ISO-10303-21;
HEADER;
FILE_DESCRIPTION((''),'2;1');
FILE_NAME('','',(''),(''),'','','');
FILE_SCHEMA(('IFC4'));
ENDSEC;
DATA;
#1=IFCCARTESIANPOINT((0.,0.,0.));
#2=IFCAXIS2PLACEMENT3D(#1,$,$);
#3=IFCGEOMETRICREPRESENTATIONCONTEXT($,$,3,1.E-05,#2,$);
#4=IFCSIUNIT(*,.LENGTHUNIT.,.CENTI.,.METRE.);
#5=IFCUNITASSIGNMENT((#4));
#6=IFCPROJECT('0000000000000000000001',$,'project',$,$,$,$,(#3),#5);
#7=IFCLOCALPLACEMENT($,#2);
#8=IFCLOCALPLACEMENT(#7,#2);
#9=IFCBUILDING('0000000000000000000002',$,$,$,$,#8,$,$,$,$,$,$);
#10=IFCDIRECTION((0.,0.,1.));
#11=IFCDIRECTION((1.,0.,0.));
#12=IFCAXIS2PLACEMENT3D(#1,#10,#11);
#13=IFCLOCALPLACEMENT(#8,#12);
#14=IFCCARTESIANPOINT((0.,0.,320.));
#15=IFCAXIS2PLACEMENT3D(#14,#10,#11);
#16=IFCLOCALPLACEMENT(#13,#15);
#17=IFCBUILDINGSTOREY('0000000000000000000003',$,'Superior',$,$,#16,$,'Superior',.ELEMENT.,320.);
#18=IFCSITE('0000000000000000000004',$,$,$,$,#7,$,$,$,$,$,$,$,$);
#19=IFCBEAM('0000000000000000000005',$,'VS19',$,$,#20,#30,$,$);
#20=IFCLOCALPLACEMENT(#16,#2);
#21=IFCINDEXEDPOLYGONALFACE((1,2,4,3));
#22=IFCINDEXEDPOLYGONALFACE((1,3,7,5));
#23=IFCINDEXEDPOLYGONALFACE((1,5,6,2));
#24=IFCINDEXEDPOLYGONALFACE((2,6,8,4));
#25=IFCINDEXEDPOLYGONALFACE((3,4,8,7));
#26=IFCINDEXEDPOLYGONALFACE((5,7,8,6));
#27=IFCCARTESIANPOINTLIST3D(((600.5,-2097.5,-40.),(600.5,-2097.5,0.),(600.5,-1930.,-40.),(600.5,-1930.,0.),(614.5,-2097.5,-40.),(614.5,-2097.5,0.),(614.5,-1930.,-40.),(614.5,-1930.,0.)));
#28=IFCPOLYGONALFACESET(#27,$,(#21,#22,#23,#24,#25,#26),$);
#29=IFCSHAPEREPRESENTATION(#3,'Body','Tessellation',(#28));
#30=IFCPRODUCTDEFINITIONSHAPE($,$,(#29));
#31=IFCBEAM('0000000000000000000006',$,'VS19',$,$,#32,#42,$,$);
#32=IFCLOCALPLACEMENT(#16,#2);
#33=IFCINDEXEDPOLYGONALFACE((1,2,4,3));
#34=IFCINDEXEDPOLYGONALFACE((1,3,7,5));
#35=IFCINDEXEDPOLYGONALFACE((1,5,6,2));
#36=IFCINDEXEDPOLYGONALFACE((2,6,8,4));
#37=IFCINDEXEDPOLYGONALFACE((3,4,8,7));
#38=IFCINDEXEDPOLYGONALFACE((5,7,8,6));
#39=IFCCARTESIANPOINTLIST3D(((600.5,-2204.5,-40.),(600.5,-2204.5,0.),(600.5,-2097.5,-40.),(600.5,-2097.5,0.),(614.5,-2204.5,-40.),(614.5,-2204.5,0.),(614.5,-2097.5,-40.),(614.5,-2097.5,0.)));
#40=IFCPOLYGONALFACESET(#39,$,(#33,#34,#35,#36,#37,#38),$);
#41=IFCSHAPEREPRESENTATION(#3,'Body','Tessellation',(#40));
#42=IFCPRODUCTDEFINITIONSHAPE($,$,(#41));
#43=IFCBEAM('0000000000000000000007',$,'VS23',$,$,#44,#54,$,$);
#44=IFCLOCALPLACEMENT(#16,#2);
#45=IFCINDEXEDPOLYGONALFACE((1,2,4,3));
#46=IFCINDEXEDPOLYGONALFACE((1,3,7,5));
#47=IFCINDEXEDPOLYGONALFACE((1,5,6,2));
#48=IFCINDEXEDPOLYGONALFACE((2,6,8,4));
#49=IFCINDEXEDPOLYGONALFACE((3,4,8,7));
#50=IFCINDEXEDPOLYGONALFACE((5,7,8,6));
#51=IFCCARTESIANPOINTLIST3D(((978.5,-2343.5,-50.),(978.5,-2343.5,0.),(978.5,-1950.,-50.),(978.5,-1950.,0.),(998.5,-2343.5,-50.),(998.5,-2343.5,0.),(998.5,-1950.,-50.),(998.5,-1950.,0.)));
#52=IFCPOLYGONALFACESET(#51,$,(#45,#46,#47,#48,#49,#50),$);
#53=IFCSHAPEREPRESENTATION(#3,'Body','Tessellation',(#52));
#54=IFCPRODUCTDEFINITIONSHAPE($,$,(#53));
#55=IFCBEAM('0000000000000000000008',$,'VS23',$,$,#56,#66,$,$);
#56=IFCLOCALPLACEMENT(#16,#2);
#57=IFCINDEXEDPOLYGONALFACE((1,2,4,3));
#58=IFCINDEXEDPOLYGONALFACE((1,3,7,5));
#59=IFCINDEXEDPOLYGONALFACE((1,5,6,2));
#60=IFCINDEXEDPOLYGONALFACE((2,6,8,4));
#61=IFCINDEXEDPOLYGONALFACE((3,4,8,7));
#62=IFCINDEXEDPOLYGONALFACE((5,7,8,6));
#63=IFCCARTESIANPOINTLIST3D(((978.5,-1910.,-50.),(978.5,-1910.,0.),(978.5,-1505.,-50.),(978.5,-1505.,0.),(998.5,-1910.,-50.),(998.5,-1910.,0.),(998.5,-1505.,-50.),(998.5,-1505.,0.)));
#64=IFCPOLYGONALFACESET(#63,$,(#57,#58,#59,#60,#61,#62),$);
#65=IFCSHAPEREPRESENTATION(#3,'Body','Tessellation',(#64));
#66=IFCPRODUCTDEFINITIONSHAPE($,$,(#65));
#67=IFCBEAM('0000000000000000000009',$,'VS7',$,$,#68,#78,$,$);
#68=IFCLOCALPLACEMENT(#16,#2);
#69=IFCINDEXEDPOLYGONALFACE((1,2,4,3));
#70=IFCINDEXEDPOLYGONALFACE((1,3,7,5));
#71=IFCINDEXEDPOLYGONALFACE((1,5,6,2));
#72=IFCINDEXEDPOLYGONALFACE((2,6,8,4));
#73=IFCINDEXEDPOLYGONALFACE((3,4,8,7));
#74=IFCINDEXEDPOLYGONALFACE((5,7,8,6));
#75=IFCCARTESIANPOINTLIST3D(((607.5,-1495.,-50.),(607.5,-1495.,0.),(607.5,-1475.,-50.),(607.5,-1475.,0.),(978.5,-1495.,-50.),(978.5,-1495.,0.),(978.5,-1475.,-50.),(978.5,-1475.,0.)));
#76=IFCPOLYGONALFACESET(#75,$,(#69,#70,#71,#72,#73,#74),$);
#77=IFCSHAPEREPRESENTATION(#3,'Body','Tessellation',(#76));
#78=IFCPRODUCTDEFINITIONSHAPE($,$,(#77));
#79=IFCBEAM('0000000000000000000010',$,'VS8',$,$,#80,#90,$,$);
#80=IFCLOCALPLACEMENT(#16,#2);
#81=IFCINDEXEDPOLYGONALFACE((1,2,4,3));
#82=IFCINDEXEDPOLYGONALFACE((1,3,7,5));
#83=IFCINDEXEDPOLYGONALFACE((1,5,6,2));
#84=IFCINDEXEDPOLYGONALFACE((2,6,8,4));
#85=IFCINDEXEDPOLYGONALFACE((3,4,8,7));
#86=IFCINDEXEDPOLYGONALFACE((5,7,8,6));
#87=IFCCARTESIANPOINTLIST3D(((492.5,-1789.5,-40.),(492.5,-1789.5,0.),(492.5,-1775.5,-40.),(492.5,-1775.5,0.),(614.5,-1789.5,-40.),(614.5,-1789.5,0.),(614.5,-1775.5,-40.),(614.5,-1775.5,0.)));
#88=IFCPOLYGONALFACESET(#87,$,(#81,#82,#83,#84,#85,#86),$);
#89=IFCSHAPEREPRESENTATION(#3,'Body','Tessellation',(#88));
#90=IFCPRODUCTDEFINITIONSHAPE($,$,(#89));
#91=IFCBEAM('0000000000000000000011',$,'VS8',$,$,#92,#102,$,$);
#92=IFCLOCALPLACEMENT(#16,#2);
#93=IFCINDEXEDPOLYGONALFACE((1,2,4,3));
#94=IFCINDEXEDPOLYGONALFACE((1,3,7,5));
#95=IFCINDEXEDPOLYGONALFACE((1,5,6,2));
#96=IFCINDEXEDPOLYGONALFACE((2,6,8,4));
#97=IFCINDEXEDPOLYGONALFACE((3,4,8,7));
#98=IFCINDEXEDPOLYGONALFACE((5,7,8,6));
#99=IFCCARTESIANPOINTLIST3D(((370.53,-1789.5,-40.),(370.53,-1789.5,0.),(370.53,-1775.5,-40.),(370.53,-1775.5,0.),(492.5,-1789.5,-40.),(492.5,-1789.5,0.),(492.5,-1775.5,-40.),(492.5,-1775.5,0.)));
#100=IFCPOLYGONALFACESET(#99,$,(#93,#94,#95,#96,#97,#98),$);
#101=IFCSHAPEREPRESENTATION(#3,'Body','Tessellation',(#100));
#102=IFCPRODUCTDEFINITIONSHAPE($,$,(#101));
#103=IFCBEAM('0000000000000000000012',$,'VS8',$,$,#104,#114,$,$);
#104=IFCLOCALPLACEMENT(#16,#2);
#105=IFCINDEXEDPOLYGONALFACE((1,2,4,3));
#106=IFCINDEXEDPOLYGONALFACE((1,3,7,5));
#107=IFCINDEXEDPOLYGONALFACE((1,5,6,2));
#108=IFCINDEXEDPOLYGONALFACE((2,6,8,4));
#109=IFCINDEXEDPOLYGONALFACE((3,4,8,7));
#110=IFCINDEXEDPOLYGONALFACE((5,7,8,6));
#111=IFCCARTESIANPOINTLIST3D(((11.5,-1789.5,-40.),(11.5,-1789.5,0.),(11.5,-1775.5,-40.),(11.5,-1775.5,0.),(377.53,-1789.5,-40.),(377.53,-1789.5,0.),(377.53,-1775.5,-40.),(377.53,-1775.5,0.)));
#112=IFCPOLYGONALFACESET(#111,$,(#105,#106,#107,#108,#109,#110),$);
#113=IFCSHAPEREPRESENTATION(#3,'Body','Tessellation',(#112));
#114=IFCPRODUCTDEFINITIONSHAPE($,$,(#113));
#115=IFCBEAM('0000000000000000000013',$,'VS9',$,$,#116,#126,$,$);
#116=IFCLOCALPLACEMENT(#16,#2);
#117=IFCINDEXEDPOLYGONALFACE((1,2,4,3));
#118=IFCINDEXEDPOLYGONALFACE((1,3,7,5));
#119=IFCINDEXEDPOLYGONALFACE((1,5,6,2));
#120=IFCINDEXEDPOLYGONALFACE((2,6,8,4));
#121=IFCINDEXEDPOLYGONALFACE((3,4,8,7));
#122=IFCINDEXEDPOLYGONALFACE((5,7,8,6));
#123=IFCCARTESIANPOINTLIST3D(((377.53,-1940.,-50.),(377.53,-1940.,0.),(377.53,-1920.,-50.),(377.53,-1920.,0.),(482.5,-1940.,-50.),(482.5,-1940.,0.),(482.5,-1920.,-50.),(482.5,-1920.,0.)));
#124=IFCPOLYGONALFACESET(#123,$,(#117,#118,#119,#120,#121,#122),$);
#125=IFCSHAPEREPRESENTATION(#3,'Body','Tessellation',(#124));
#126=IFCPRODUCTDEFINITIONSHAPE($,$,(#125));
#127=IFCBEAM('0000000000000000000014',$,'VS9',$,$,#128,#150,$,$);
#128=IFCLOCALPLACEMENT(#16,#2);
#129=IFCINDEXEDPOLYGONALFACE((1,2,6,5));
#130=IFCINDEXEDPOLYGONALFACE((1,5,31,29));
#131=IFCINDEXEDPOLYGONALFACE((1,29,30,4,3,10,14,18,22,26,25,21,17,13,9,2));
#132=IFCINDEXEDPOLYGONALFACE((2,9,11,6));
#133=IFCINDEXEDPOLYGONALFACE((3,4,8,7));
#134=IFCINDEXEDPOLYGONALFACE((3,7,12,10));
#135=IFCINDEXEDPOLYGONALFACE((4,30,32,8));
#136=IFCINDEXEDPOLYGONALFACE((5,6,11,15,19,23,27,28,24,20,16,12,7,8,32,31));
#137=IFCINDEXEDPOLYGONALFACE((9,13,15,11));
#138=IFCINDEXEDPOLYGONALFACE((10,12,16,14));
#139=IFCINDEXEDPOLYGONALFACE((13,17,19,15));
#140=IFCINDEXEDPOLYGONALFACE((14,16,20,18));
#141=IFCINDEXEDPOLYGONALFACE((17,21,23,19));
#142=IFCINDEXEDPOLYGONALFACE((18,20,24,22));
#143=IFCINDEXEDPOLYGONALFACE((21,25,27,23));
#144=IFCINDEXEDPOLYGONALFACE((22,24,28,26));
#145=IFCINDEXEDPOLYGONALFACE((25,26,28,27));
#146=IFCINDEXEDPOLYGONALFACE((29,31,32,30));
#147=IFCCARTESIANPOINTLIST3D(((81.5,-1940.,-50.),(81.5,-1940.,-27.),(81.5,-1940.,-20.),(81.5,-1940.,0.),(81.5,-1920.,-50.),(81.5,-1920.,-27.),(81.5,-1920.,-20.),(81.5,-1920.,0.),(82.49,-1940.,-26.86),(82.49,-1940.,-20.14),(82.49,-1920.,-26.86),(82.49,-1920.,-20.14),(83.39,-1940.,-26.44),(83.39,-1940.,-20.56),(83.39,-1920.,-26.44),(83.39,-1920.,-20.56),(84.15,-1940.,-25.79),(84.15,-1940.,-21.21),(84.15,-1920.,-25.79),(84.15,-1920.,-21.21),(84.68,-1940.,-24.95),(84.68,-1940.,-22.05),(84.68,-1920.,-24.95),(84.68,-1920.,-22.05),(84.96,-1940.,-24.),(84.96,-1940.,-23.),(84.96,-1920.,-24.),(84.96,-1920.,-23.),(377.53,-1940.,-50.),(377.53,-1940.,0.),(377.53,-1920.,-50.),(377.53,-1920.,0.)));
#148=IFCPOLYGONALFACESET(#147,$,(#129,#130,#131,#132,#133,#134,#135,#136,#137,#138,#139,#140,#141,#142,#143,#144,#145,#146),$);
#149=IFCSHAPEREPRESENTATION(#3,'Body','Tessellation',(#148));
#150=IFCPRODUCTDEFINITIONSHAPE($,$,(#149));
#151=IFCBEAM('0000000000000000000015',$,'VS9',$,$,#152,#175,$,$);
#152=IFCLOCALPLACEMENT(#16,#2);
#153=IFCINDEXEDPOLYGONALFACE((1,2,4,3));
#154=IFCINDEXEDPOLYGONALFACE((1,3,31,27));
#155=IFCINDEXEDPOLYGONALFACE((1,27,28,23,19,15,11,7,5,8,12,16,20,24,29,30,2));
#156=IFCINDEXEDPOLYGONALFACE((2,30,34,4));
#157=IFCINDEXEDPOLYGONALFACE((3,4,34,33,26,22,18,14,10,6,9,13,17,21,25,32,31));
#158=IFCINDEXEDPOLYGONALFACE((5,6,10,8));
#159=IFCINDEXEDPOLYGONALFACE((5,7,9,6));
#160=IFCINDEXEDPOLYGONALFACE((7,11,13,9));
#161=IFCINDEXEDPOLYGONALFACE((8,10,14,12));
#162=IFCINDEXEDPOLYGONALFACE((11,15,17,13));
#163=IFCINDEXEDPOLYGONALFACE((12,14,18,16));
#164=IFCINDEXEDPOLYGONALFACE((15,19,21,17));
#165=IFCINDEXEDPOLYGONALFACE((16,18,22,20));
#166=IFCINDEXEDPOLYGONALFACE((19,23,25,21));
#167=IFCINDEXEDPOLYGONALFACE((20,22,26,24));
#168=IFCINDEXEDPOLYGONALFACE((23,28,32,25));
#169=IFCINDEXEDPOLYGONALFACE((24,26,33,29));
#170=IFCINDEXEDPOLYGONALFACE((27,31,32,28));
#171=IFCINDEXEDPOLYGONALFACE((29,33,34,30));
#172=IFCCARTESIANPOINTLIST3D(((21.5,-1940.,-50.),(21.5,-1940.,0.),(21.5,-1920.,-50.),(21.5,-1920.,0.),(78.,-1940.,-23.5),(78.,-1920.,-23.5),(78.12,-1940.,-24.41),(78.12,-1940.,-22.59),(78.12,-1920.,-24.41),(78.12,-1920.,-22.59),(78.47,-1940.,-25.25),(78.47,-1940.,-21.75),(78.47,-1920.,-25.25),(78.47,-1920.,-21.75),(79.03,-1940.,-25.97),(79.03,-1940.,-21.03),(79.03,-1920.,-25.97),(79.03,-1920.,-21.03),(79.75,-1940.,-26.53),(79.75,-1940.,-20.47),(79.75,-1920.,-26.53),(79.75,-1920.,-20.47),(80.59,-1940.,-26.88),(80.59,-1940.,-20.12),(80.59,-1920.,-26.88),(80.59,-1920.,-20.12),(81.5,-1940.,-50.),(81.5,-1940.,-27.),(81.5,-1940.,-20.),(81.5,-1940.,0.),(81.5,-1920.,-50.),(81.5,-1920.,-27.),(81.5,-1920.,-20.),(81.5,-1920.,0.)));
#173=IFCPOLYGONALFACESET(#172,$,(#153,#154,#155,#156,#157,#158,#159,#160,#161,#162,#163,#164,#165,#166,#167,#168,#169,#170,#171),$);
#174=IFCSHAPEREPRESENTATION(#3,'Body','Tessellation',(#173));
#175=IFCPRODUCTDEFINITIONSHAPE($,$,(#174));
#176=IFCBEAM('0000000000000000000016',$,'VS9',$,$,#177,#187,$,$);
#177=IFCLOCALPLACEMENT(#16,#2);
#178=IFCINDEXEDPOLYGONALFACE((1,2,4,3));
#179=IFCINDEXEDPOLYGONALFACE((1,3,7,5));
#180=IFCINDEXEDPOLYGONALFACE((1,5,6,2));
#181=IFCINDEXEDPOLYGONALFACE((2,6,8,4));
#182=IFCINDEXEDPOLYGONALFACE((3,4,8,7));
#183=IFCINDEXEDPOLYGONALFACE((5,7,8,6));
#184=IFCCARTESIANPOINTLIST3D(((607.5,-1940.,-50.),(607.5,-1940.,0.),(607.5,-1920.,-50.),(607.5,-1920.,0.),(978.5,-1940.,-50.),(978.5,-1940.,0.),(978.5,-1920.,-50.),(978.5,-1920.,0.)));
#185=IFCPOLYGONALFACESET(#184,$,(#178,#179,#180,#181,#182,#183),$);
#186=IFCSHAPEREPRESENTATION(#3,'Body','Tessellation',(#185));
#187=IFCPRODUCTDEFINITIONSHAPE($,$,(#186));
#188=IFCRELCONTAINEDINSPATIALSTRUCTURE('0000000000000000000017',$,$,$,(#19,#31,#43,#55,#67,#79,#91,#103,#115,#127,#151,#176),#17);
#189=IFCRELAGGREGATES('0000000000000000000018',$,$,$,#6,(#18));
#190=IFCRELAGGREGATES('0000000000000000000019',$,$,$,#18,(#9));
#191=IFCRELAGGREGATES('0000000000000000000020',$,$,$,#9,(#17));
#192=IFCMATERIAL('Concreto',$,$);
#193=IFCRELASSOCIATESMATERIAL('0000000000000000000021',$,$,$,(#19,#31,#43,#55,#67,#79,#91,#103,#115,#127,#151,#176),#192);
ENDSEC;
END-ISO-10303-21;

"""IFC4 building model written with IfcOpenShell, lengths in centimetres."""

from ifc_helpers import new_model, si_unit, frame, origin, origin_with_axes, origin_2d_with_axis, place, context, project, spatial, polyline, circle, outline, extrude, material, element, save


model = new_model("IFC4")

# Units and contexts
context_of_model = context(None, 3, precision=1e-05, world=origin())
ifc_project = project(units=[si_unit("LENGTHUNIT", "METRE", prefix="CENTI")], contexts=[context_of_model])

# Site, building, storey
site_placement = place(None, origin())
site = spatial("IfcSite", under=ifc_project, at=site_placement)
building_placement = place(site_placement, origin())
building = spatial("IfcBuilding", under=site, at=building_placement)
placement = place(building_placement, origin_with_axes())
storey_placement = place(placement, frame((0.0, 0.0, 320.0), z_axis=(0.0, 0.0, 1.0), x_axis=(1.0, 0.0, 0.0)))
storey = spatial("IfcBuildingStorey", under=building, at=storey_placement, Name="Superior", LongName="Superior", CompositionType="ELEMENT", Elevation=320.0)

# Shared definitions
ifc_material = material(Name="Concreto")

# Beams
beam_1_placement = place(storey_placement, frame((607.5, -2013.75, 0.0), z_axis=(0.0, 0.0, 1.0), x_axis=(1.0, 0.0, 0.0)))
element("IfcBeam", 1, at=beam_1_placement, inside=storey, material=ifc_material, Name="VS19", context=context_of_model, shape_type="SolidModel", body=[
    extrude(outline(polyline([(-7.0, -20.0), (7.0, -20.0), (7.0, 20.0), (-7.0, 20.0), (-7.0, -20.0)])), frame((0.0, -83.75, -20.0), z_axis=(0.0, 1.0, 0.0), x_axis=(1.0, 0.0, 0.0)), (0.0, 0.0, 1.0), 167.5),
])
beam_2_placement = place(storey_placement, frame((607.5, -2151.0, 0.0), z_axis=(0.0, 0.0, 1.0), x_axis=(1.0, 0.0, 0.0)))
element("IfcBeam", 2, at=beam_2_placement, inside=storey, material=ifc_material, Name="VS19", context=context_of_model, shape_type="SolidModel", body=[
    extrude(outline(polyline([(-7.0, -20.0), (7.0, -20.0), (7.0, 20.0), (-7.0, 20.0), (-7.0, -20.0)])), frame((0.0, -53.5, -20.0), z_axis=(0.0, 1.0, 0.0), x_axis=(1.0, 0.0, 0.0)), (0.0, 0.0, 1.0), 107.0),
])
beam_3_placement = place(storey_placement, frame((988.5, -2146.75, 0.0), z_axis=(0.0, 0.0, 1.0), x_axis=(1.0, 0.0, 0.0)))
element("IfcBeam", 3, at=beam_3_placement, inside=storey, material=ifc_material, Name="VS23", context=context_of_model, shape_type="SolidModel", body=[
    extrude(outline(polyline([(-10.0, -25.0), (10.0, -25.0), (10.0, 25.0), (-10.0, 25.0), (-10.0, -25.0)])), frame((0.0, -196.75, -25.0), z_axis=(0.0, 1.0, 0.0), x_axis=(1.0, 0.0, 0.0)), (0.0, 0.0, 1.0), 393.5),
])
beam_4_placement = place(storey_placement, frame((988.5, -1707.5, 0.0), z_axis=(0.0, 0.0, 1.0), x_axis=(1.0, 0.0, 0.0)))
element("IfcBeam", 4, at=beam_4_placement, inside=storey, material=ifc_material, Name="VS23", context=context_of_model, shape_type="SolidModel", body=[
    extrude(outline(polyline([(-10.0, -25.0), (10.0, -25.0), (10.0, 25.0), (-10.0, 25.0), (-10.0, -25.0)])), frame((0.0, -202.5, -25.0), z_axis=(0.0, 1.0, 0.0), x_axis=(1.0, 0.0, 0.0)), (0.0, 0.0, 1.0), 405.0),
])
beam_5_placement = place(storey_placement, frame((793.0, -1485.0, 0.0), z_axis=(0.0, 0.0, 1.0), x_axis=(1.0, 0.0, 0.0)))
element("IfcBeam", 5, at=beam_5_placement, inside=storey, material=ifc_material, Name="VS7", context=context_of_model, shape_type="SolidModel", body=[
    extrude(outline(polyline([(-10.0, -25.0), (10.0, -25.0), (10.0, 25.0), (-10.0, 25.0), (-10.0, -25.0)])), frame((-185.5, 0.0, -25.0), z_axis=(1.0, 0.0, 0.0), x_axis=(0.0, -1.0, 0.0)), (0.0, 0.0, 1.0), 371.0),
])
beam_6_placement = place(storey_placement, frame((553.5, -1782.5, 0.0), z_axis=(0.0, 0.0, 1.0), x_axis=(1.0, 0.0, 0.0)))
element("IfcBeam", 6, at=beam_6_placement, inside=storey, material=ifc_material, Name="VS8", context=context_of_model, shape_type="SolidModel", body=[
    extrude(outline(polyline([(-7.0, -20.0), (7.0, -20.0), (7.0, 20.0), (-7.0, 20.0), (-7.0, -20.0)])), frame((-61.0, 0.0, -20.0), z_axis=(1.0, 0.0, 0.0), x_axis=(0.0, -1.0, 0.0)), (0.0, 0.0, 1.0), 122.0),
])
beam_7_placement = place(storey_placement, frame((431.51, -1782.5, 0.0), z_axis=(0.0, 0.0, 1.0), x_axis=(1.0, 0.0, 0.0)))
element("IfcBeam", 7, at=beam_7_placement, inside=storey, material=ifc_material, Name="VS8", context=context_of_model, shape_type="SolidModel", body=[
    extrude(outline(polyline([(-7.0, -20.0), (7.0, -20.0), (7.0, 20.0), (-7.0, 20.0), (-7.0, -20.0)])), frame((-60.98, 0.0, -20.0), z_axis=(1.0, 0.0, 0.0), x_axis=(0.0, -1.0, 0.0)), (0.0, 0.0, 1.0), 121.97),
])
beam_8_placement = place(storey_placement, frame((194.51, -1782.5, 0.0), z_axis=(0.0, 0.0, 1.0), x_axis=(1.0, 0.0, 0.0)))
element("IfcBeam", 8, at=beam_8_placement, inside=storey, material=ifc_material, Name="VS8", context=context_of_model, shape_type="SolidModel", body=[
    extrude(outline(polyline([(-7.0, -20.0), (7.0, -20.0), (7.0, 20.0), (-7.0, 20.0), (-7.0, -20.0)])), frame((-183.01, 0.0, -20.0), z_axis=(1.0, 0.0, 0.0), x_axis=(0.0, -1.0, 0.0)), (0.0, 0.0, 1.0), 366.03),
])
beam_9_placement = place(storey_placement, frame((430.01, -1930.0, 0.0), z_axis=(0.0, 0.0, 1.0), x_axis=(1.0, 0.0, 0.0)))
element("IfcBeam", 9, at=beam_9_placement, inside=storey, material=ifc_material, Name="VS9", context=context_of_model, shape_type="SolidModel", body=[
    extrude(outline(polyline([(-10.0, -25.0), (10.0, -25.0), (10.0, 25.0), (-10.0, 25.0), (-10.0, -25.0)])), frame((-52.48, 0.0, -25.0), z_axis=(1.0, 0.0, 0.0), x_axis=(0.0, -1.0, 0.0)), (0.0, 0.0, 1.0), 104.97),
])

# Beams, openings
beam_10_placement = place(storey_placement, frame((229.51, -1930.0, 0.0), z_axis=(0.0, 0.0, 1.0), x_axis=(1.0, 0.0, 0.0)))
beam_10 = element("IfcBeam", 10, at=beam_10_placement, inside=storey, material=ifc_material, Name="VS9", context=context_of_model, shape_type="SolidModel", body=[
    extrude(outline(polyline([(-10.0, -25.0), (10.0, -25.0), (10.0, 25.0), (-10.0, 25.0), (-10.0, -25.0)])), frame((-148.01, 0.0, -25.0), z_axis=(1.0, 0.0, 0.0), x_axis=(0.0, -1.0, 0.0)), (0.0, 0.0, 1.0), 296.03),
])
opening_1_placement = place(storey_placement, frame((0.0, 0.0, -320.0), z_axis=(0.0, 0.0, 1.0), x_axis=(1.0, 0.0, 0.0)))
element("IfcOpeningElement", 11, at=opening_1_placement, cuts=beam_10, material=ifc_material, context=context_of_model, shape_type="SweptSolid", body=[
    extrude(circle(Radius=3.5, at=origin_2d_with_axis()), frame((81.5, -1940.0, 296.5), z_axis=(0.0, 1.0, 0.0), x_axis=(-1.0, 0.0, 0.0)), (0.0, 0.0, 1.0), 20.0),
])
beam_11_placement = place(storey_placement, frame((51.5, -1930.0, 0.0), z_axis=(0.0, 0.0, 1.0), x_axis=(1.0, 0.0, 0.0)))
beam_11 = element("IfcBeam", 12, at=beam_11_placement, inside=storey, material=ifc_material, Name="VS9", context=context_of_model, shape_type="SolidModel", body=[
    extrude(outline(polyline([(-10.0, -25.0), (10.0, -25.0), (10.0, 25.0), (-10.0, 25.0), (-10.0, -25.0)])), frame((-30.0, 0.0, -25.0), z_axis=(1.0, 0.0, 0.0), x_axis=(0.0, -1.0, 0.0)), (0.0, 0.0, 1.0), 60.0),
])
opening_2_placement = place(storey_placement, frame((0.0, 0.0, -320.0), z_axis=(0.0, 0.0, 1.0), x_axis=(1.0, 0.0, 0.0)))
element("IfcOpeningElement", 13, at=opening_2_placement, cuts=beam_11, material=ifc_material, context=context_of_model, shape_type="SweptSolid", body=[
    extrude(circle(Radius=3.5, at=origin_2d_with_axis()), frame((81.5, -1940.0, 296.5), z_axis=(0.0, 1.0, 0.0), x_axis=(-1.0, 0.0, 0.0)), (0.0, 0.0, 1.0), 20.0),
])

# Beam
beam_12_placement = place(storey_placement, frame((793.0, -1930.0, 0.0), z_axis=(0.0, 0.0, 1.0), x_axis=(1.0, 0.0, 0.0)))
element("IfcBeam", 14, at=beam_12_placement, inside=storey, material=ifc_material, Name="VS9", context=context_of_model, shape_type="SolidModel", body=[
    extrude(outline(polyline([(-10.0, -25.0), (10.0, -25.0), (10.0, 25.0), (-10.0, 25.0), (-10.0, -25.0)])), frame((-185.5, 0.0, -25.0), z_axis=(1.0, 0.0, 0.0), x_axis=(0.0, -1.0, 0.0)), (0.0, 0.0, 1.0), 371.0),
])

save(model, "model.ifc")
